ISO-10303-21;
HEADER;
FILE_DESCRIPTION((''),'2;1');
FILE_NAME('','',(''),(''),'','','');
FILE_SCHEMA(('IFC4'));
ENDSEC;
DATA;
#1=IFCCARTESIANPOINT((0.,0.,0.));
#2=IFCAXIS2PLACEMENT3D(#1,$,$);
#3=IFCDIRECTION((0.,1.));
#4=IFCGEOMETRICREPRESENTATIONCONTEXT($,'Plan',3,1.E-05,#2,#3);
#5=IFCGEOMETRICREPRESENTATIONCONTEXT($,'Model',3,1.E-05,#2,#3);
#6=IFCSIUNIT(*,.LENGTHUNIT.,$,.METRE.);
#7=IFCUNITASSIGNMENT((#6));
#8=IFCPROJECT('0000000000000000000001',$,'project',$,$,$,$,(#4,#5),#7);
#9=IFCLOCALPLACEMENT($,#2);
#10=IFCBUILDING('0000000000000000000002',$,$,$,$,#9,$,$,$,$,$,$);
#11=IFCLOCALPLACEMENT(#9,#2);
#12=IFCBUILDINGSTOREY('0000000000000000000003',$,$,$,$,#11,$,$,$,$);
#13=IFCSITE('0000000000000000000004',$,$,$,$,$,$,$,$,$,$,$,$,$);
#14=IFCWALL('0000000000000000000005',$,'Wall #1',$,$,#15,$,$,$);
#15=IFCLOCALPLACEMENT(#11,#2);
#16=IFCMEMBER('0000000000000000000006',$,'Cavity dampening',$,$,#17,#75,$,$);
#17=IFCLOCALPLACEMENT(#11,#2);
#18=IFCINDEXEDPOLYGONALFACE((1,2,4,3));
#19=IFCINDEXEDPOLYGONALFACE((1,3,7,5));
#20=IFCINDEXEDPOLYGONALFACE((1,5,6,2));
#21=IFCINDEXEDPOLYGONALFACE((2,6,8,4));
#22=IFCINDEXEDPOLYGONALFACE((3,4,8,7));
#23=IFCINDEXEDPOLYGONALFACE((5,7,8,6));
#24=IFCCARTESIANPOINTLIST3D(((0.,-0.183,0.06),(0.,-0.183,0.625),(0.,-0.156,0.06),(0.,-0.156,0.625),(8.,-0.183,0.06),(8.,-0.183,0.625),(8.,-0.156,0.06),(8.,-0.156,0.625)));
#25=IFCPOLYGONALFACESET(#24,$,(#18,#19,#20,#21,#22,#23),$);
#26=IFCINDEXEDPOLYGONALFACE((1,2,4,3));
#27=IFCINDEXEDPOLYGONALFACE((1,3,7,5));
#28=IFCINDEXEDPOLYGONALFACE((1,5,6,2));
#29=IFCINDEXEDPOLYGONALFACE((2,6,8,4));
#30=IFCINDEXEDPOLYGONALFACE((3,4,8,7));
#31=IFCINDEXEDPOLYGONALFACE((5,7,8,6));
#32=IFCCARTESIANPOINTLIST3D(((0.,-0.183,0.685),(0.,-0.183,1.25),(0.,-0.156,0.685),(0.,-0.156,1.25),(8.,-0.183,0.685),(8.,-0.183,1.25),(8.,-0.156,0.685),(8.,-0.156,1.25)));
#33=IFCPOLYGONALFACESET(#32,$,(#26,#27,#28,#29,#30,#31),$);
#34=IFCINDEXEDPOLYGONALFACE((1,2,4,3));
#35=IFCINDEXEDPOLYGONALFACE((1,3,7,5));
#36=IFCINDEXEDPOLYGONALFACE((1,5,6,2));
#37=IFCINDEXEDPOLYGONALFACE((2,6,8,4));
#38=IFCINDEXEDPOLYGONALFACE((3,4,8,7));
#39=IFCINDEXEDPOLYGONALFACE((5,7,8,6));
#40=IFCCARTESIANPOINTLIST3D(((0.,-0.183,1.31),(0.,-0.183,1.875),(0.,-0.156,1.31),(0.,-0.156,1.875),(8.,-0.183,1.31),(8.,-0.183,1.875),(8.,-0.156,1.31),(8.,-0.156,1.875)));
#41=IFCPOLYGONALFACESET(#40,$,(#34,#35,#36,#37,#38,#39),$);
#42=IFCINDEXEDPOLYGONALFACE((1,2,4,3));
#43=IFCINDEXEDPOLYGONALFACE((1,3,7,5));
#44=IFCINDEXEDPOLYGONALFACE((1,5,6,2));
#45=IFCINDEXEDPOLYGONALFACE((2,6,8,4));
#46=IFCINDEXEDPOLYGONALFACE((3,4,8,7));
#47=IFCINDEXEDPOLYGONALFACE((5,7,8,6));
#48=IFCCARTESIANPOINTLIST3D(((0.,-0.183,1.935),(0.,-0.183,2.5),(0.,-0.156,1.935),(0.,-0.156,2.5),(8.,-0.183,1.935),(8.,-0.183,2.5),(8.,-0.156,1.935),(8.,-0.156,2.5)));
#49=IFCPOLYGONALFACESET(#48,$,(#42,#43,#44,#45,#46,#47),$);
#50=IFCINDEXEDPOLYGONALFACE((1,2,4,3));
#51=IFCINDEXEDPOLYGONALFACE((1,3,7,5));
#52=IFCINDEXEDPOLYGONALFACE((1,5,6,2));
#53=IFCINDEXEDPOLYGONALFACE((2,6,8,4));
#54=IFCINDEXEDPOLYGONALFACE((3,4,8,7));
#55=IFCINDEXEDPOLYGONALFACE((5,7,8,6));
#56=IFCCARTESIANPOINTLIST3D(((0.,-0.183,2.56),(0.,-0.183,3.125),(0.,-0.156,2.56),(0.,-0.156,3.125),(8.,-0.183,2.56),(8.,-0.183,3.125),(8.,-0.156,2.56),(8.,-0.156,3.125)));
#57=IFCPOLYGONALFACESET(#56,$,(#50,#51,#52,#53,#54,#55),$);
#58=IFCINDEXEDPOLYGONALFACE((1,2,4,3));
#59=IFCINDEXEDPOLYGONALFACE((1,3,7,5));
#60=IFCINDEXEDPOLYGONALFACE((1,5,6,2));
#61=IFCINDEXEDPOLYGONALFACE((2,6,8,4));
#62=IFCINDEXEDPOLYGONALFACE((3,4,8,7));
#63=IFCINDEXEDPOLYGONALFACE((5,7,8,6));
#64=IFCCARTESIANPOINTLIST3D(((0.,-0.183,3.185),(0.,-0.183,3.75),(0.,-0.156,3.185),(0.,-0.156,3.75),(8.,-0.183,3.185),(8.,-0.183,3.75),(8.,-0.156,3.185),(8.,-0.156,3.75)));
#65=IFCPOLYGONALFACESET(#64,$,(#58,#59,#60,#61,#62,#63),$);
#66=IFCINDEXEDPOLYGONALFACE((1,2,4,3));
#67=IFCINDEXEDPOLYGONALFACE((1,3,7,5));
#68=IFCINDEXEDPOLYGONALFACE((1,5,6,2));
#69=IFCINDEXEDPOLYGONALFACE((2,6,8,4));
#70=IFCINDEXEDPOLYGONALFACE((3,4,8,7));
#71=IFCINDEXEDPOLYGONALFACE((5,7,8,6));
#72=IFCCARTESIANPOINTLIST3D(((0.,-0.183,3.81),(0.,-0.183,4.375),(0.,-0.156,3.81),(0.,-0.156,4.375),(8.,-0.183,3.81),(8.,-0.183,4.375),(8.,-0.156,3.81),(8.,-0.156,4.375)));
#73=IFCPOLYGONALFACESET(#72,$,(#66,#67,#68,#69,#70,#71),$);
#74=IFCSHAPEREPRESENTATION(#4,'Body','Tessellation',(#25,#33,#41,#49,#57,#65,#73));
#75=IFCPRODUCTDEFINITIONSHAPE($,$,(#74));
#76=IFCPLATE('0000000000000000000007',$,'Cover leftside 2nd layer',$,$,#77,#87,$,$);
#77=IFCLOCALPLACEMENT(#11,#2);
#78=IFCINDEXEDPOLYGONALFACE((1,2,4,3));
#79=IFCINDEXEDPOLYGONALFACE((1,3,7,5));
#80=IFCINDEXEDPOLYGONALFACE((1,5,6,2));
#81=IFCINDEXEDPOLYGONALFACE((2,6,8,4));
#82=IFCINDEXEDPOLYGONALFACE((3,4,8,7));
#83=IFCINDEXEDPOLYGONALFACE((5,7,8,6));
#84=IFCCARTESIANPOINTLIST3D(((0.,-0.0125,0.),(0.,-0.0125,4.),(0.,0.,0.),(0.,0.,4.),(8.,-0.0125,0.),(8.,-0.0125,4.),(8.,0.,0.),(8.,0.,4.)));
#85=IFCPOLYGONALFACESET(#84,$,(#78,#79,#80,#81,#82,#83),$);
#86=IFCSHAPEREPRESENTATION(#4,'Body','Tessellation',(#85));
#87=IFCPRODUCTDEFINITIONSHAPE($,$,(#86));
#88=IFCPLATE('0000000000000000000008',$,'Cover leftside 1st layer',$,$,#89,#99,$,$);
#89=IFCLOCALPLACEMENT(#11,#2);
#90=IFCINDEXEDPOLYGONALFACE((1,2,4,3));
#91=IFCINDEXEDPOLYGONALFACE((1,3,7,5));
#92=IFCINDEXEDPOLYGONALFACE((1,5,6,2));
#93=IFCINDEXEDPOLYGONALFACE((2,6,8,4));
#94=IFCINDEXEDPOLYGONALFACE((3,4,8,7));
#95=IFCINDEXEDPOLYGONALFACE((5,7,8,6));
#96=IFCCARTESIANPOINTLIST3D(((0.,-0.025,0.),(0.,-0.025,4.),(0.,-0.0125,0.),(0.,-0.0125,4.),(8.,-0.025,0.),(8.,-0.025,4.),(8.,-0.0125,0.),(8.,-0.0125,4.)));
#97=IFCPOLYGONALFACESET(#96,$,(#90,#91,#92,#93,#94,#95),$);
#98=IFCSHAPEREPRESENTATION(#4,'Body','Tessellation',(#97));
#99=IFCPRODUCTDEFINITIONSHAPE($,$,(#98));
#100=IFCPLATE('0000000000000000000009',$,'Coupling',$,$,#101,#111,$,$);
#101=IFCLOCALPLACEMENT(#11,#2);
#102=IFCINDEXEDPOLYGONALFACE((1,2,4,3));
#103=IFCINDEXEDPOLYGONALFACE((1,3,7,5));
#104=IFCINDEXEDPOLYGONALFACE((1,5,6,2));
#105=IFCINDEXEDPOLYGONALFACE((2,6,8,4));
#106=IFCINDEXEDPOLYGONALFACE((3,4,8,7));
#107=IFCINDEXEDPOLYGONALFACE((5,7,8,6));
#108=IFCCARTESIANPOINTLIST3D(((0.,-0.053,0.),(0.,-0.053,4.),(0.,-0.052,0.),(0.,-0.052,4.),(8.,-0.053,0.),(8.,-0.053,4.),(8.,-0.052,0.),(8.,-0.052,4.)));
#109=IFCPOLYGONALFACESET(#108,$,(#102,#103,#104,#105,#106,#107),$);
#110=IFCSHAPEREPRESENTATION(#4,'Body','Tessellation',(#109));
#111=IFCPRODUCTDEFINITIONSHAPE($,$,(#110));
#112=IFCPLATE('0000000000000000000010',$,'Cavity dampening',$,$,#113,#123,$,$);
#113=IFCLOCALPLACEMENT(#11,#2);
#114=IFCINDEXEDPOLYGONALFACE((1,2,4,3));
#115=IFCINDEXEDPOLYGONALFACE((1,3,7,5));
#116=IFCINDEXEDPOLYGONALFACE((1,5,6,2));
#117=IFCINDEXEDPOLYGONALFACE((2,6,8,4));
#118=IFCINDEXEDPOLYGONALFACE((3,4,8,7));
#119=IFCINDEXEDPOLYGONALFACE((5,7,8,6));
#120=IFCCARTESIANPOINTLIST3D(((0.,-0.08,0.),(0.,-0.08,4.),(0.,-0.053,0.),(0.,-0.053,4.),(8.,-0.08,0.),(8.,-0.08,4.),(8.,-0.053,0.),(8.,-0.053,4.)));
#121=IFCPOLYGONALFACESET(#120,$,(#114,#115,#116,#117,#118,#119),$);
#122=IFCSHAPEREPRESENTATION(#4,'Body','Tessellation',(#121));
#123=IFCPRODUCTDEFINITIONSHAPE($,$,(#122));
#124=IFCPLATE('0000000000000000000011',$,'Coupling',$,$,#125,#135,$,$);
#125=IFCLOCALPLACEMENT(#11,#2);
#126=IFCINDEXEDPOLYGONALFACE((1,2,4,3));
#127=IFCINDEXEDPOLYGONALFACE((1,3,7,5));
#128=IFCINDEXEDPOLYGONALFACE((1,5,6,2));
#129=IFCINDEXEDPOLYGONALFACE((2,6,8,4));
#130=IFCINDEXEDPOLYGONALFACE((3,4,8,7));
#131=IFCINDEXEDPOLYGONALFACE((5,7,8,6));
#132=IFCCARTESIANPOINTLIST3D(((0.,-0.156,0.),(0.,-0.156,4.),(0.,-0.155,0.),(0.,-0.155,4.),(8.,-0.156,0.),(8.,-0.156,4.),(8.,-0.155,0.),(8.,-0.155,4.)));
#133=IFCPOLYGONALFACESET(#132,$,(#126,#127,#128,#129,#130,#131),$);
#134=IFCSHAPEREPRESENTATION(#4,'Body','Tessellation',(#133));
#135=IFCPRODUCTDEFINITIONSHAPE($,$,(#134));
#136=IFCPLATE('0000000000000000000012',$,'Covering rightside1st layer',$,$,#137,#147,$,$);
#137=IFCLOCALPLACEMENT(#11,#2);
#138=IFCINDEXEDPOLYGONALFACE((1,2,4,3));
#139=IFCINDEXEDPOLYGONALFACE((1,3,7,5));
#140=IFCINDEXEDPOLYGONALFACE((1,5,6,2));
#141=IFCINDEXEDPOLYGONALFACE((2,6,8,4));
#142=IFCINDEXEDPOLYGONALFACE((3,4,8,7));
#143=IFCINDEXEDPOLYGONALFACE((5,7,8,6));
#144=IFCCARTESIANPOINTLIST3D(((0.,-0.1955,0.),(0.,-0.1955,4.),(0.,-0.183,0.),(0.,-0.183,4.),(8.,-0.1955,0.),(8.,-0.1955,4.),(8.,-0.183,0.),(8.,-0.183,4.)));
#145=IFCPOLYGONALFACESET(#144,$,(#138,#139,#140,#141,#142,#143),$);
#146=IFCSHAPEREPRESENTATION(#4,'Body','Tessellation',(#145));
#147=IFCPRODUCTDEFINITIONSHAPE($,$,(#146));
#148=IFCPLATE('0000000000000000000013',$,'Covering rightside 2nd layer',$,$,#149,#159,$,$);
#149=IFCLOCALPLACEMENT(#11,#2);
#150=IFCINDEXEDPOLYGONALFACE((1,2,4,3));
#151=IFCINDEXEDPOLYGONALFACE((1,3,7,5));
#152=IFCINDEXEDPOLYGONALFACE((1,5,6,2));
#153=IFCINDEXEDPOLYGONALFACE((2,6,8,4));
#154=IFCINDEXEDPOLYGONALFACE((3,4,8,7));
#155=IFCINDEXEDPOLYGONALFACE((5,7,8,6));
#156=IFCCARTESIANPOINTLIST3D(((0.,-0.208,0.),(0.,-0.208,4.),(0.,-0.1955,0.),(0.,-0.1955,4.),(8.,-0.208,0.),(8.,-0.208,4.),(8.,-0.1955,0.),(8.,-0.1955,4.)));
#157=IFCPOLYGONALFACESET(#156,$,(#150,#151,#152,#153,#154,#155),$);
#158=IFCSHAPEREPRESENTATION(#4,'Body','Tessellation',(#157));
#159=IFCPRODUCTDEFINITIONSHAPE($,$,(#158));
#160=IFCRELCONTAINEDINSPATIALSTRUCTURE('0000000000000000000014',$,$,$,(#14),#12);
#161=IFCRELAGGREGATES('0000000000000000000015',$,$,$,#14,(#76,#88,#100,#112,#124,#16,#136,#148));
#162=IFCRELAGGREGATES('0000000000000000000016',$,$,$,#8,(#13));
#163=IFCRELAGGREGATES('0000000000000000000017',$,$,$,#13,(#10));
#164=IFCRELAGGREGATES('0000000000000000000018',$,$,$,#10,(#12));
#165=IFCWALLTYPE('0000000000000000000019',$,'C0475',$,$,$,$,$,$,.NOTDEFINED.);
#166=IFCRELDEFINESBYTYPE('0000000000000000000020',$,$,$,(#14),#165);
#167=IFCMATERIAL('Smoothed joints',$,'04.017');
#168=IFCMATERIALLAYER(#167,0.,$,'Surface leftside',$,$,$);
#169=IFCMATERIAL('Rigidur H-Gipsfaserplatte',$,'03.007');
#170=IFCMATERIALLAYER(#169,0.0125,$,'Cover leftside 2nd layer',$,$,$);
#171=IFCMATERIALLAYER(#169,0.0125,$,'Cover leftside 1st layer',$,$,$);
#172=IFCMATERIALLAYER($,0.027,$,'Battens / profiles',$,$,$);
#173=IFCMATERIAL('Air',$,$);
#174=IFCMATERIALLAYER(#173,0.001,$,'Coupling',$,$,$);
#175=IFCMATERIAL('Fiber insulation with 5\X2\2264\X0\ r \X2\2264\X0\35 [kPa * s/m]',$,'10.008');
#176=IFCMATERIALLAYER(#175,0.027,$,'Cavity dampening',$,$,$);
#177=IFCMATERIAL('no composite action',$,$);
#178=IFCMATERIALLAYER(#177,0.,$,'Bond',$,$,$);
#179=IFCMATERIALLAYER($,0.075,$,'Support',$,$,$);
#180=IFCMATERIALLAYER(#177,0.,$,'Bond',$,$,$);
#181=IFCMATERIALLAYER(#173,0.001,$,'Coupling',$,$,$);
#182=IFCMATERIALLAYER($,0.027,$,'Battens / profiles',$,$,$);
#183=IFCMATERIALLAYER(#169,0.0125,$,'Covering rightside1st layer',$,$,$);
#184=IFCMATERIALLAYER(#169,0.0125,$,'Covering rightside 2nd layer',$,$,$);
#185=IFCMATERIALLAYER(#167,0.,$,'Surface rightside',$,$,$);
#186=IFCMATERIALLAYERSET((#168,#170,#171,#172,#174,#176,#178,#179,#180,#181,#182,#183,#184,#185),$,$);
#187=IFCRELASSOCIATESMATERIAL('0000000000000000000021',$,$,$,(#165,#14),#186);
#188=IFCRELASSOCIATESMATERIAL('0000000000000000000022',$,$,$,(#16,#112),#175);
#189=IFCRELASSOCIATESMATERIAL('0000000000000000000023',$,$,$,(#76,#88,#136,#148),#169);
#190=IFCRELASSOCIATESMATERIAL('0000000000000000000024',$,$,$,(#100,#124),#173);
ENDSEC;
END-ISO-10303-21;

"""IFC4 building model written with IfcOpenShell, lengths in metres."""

from ifc_helpers import new_model, si_unit, direction, frame, frame_2d, origin, origin_with_axes, place, context, project, spatial, rectangle, extrude, material, layer, layer_set, type_object, element, aggregate, save


model = new_model("IFC4")

# Units and contexts
plan_context = context("Plan", 3, precision=1e-05, world=origin(), true_north=direction((0.0, 1.0)))
model_context = context("Model", 3, precision=1e-05, world=origin(), true_north=direction((0.0, 1.0)))
ifc_project = project(units=[si_unit("LENGTHUNIT", "METRE")], contexts=[plan_context, model_context])

# Site, building, storey
site = spatial("IfcSite", under=ifc_project)
building_placement = place(None, origin())
building = spatial("IfcBuilding", under=site, at=building_placement)
storey_placement = place(building_placement, origin())
storey = spatial("IfcBuildingStorey", under=building, at=storey_placement)

# Wall, member, plates
ifc_material_1 = material(Name="Smoothed joints", Category="04.017")
ifc_layer_1 = layer(ifc_material_1, 0.0, Name="Surface leftside")
ifc_material_2 = material(Name="Rigidur H-Gipsfaserplatte", Category="03.007")
ifc_layer_2 = layer(ifc_material_2, 0.0125, Name="Cover leftside 2nd layer")
ifc_layer_3 = layer(ifc_material_2, 0.0125, Name="Cover leftside 1st layer")
ifc_layer_4 = layer(None, 0.027, Name="Battens / profiles")
ifc_material_3 = material(Name="Air")
ifc_layer_5 = layer(ifc_material_3, 0.001, Name="Coupling")
ifc_material_4 = material(Name="Fiber insulation with 5≤ r ≤35 [kPa * s/m]", Category="10.008")
ifc_layer_6 = layer(ifc_material_4, 0.027, Name="Cavity dampening")
ifc_material_5 = material(Name="no composite action")
ifc_layer_7 = layer(ifc_material_5, 0.0, Name="Bond")
ifc_layer_8 = layer(None, 0.075, Name="Support")
ifc_layer_9 = layer(ifc_material_5, 0.0, Name="Bond")
ifc_layer_10 = layer(ifc_material_3, 0.001, Name="Coupling")
ifc_layer_11 = layer(None, 0.027, Name="Battens / profiles")
ifc_layer_12 = layer(ifc_material_2, 0.0125, Name="Covering rightside1st layer")
ifc_layer_13 = layer(ifc_material_2, 0.0125, Name="Covering rightside 2nd layer")
ifc_layer_14 = layer(ifc_material_1, 0.0, Name="Surface rightside")
ifc_layer_set = layer_set([ifc_layer_1, ifc_layer_2, ifc_layer_3, ifc_layer_4, ifc_layer_5, ifc_layer_6, ifc_layer_7, ifc_layer_8, ifc_layer_9, ifc_layer_10, ifc_layer_11, ifc_layer_12, ifc_layer_13, ifc_layer_14])
wall_type = type_object("IfcWallType", Name="C0475", PredefinedType="NOTDEFINED", material=ifc_layer_set)
wall_placement = place(None, frame((0.0, 0.0, 0.0), z_axis=(0.0, -1.0, 0.0), x_axis=(1.0, 0.0, 0.0)))
wall = element("IfcWall", 1, at=wall_placement, inside=storey, type_object=wall_type, material=ifc_layer_set, Name="Wall #1")
member_1_placement = place(wall_placement, origin())
member_1 = element("IfcMember", 2, at=member_1_placement, material=ifc_material_4, Name="Cavity dampening", context=plan_context, shape_type="SweptSolid", body=[
    extrude(rectangle(XDim=0.565, YDim=0.027, at=frame_2d((0.2825, 0.0135), x_axis=(1.0, 0.0))), frame((0.0, 0.06, 0.156), z_axis=(1.0, 0.0, 0.0), x_axis=(0.0, 1.0, 0.0)), (0.0, 0.0, 1.0), 8.0),
    extrude(rectangle(XDim=0.565, YDim=0.027, at=frame_2d((0.2825, 0.0135), x_axis=(1.0, 0.0))), frame((0.0, 0.685, 0.156), z_axis=(1.0, 0.0, 0.0), x_axis=(0.0, 1.0, 0.0)), (0.0, 0.0, 1.0), 8.0),
    extrude(rectangle(XDim=0.565, YDim=0.027, at=frame_2d((0.2825, 0.0135), x_axis=(1.0, 0.0))), frame((0.0, 1.31, 0.156), z_axis=(1.0, 0.0, 0.0), x_axis=(0.0, 1.0, 0.0)), (0.0, 0.0, 1.0), 8.0),
    extrude(rectangle(XDim=0.565, YDim=0.027, at=frame_2d((0.2825, 0.0135), x_axis=(1.0, 0.0))), frame((0.0, 1.935, 0.156), z_axis=(1.0, 0.0, 0.0), x_axis=(0.0, 1.0, 0.0)), (0.0, 0.0, 1.0), 8.0),
    extrude(rectangle(XDim=0.565, YDim=0.027, at=frame_2d((0.2825, 0.0135), x_axis=(1.0, 0.0))), frame((0.0, 2.56, 0.156), z_axis=(1.0, 0.0, 0.0), x_axis=(0.0, 1.0, 0.0)), (0.0, 0.0, 1.0), 8.0),
    extrude(rectangle(XDim=0.565, YDim=0.027, at=frame_2d((0.2825, 0.0135), x_axis=(1.0, 0.0))), frame((0.0, 3.185, 0.156), z_axis=(1.0, 0.0, 0.0), x_axis=(0.0, 1.0, 0.0)), (0.0, 0.0, 1.0), 8.0),
    extrude(rectangle(XDim=0.565, YDim=0.027, at=frame_2d((0.2825, 0.0135), x_axis=(1.0, 0.0))), frame((0.0, 3.81, 0.156), z_axis=(1.0, 0.0, 0.0), x_axis=(0.0, 1.0, 0.0)), (0.0, 0.0, 1.0), 8.0),
])
plate_1_placement = place(wall_placement, origin())
plate_1 = element("IfcPlate", 3, at=plate_1_placement, material=ifc_material_2, Name="Cover leftside 2nd layer", context=plan_context, shape_type="SweptSolid", body=[
    extrude(rectangle(XDim=8.0, YDim=4.0, at=frame_2d((4.0, 2.0), x_axis=(1.0, 0.0))), origin_with_axes(), (0.0, 0.0, 1.0), 0.0125),
])
plate_2_placement = place(wall_placement, origin())
plate_2 = element("IfcPlate", 4, at=plate_2_placement, material=ifc_material_2, Name="Cover leftside 1st layer", context=plan_context, shape_type="SweptSolid", body=[
    extrude(rectangle(XDim=8.0, YDim=4.0, at=frame_2d((4.0, 2.0), x_axis=(1.0, 0.0))), frame((0.0, 0.0, 0.0125), z_axis=(0.0, 0.0, 1.0), x_axis=(1.0, 0.0, 0.0)), (0.0, 0.0, 1.0), 0.0125),
])
plate_3_placement = place(wall_placement, origin())
plate_3 = element("IfcPlate", 5, at=plate_3_placement, material=ifc_material_3, Name="Coupling", context=plan_context, shape_type="SweptSolid", body=[
    extrude(rectangle(XDim=8.0, YDim=4.0, at=frame_2d((4.0, 2.0), x_axis=(1.0, 0.0))), frame((0.0, 0.0, 0.052), z_axis=(0.0, 0.0, 1.0), x_axis=(1.0, 0.0, 0.0)), (0.0, 0.0, 1.0), 0.001),
])
plate_4_placement = place(wall_placement, origin())
plate_4 = element("IfcPlate", 6, at=plate_4_placement, material=ifc_material_4, Name="Cavity dampening", context=plan_context, shape_type="SweptSolid", body=[
    extrude(rectangle(XDim=8.0, YDim=4.0, at=frame_2d((4.0, 2.0), x_axis=(1.0, 0.0))), frame((0.0, 0.0, 0.053), z_axis=(0.0, 0.0, 1.0), x_axis=(1.0, 0.0, 0.0)), (0.0, 0.0, 1.0), 0.027),
])
plate_5_placement = place(wall_placement, origin())
plate_5 = element("IfcPlate", 7, at=plate_5_placement, material=ifc_material_3, Name="Coupling", context=plan_context, shape_type="SweptSolid", body=[
    extrude(rectangle(XDim=8.0, YDim=4.0, at=frame_2d((4.0, 2.0), x_axis=(1.0, 0.0))), frame((0.0, 0.0, 0.155), z_axis=(0.0, 0.0, 1.0), x_axis=(1.0, 0.0, 0.0)), (0.0, 0.0, 1.0), 0.001),
])
plate_6_placement = place(wall_placement, origin())
plate_6 = element("IfcPlate", 8, at=plate_6_placement, material=ifc_material_2, Name="Covering rightside1st layer", context=plan_context, shape_type="SweptSolid", body=[
    extrude(rectangle(XDim=8.0, YDim=4.0, at=frame_2d((4.0, 2.0), x_axis=(1.0, 0.0))), frame((0.0, 0.0, 0.183), z_axis=(0.0, 0.0, 1.0), x_axis=(1.0, 0.0, 0.0)), (0.0, 0.0, 1.0), 0.0125),
])
plate_7_placement = place(wall_placement, origin())
plate_7 = element("IfcPlate", 9, at=plate_7_placement, material=ifc_material_2, Name="Covering rightside 2nd layer", context=plan_context, shape_type="SweptSolid", body=[
    extrude(rectangle(XDim=8.0, YDim=4.0, at=frame_2d((4.0, 2.0), x_axis=(1.0, 0.0))), frame((0.0, 0.0, 0.1955), z_axis=(0.0, 0.0, 1.0), x_axis=(1.0, 0.0, 0.0)), (0.0, 0.0, 1.0), 0.0125),
])
aggregate(wall, [plate_1, plate_2, plate_3, plate_4, plate_5, member_1, plate_6, plate_7])

save(model, "model.ifc")
